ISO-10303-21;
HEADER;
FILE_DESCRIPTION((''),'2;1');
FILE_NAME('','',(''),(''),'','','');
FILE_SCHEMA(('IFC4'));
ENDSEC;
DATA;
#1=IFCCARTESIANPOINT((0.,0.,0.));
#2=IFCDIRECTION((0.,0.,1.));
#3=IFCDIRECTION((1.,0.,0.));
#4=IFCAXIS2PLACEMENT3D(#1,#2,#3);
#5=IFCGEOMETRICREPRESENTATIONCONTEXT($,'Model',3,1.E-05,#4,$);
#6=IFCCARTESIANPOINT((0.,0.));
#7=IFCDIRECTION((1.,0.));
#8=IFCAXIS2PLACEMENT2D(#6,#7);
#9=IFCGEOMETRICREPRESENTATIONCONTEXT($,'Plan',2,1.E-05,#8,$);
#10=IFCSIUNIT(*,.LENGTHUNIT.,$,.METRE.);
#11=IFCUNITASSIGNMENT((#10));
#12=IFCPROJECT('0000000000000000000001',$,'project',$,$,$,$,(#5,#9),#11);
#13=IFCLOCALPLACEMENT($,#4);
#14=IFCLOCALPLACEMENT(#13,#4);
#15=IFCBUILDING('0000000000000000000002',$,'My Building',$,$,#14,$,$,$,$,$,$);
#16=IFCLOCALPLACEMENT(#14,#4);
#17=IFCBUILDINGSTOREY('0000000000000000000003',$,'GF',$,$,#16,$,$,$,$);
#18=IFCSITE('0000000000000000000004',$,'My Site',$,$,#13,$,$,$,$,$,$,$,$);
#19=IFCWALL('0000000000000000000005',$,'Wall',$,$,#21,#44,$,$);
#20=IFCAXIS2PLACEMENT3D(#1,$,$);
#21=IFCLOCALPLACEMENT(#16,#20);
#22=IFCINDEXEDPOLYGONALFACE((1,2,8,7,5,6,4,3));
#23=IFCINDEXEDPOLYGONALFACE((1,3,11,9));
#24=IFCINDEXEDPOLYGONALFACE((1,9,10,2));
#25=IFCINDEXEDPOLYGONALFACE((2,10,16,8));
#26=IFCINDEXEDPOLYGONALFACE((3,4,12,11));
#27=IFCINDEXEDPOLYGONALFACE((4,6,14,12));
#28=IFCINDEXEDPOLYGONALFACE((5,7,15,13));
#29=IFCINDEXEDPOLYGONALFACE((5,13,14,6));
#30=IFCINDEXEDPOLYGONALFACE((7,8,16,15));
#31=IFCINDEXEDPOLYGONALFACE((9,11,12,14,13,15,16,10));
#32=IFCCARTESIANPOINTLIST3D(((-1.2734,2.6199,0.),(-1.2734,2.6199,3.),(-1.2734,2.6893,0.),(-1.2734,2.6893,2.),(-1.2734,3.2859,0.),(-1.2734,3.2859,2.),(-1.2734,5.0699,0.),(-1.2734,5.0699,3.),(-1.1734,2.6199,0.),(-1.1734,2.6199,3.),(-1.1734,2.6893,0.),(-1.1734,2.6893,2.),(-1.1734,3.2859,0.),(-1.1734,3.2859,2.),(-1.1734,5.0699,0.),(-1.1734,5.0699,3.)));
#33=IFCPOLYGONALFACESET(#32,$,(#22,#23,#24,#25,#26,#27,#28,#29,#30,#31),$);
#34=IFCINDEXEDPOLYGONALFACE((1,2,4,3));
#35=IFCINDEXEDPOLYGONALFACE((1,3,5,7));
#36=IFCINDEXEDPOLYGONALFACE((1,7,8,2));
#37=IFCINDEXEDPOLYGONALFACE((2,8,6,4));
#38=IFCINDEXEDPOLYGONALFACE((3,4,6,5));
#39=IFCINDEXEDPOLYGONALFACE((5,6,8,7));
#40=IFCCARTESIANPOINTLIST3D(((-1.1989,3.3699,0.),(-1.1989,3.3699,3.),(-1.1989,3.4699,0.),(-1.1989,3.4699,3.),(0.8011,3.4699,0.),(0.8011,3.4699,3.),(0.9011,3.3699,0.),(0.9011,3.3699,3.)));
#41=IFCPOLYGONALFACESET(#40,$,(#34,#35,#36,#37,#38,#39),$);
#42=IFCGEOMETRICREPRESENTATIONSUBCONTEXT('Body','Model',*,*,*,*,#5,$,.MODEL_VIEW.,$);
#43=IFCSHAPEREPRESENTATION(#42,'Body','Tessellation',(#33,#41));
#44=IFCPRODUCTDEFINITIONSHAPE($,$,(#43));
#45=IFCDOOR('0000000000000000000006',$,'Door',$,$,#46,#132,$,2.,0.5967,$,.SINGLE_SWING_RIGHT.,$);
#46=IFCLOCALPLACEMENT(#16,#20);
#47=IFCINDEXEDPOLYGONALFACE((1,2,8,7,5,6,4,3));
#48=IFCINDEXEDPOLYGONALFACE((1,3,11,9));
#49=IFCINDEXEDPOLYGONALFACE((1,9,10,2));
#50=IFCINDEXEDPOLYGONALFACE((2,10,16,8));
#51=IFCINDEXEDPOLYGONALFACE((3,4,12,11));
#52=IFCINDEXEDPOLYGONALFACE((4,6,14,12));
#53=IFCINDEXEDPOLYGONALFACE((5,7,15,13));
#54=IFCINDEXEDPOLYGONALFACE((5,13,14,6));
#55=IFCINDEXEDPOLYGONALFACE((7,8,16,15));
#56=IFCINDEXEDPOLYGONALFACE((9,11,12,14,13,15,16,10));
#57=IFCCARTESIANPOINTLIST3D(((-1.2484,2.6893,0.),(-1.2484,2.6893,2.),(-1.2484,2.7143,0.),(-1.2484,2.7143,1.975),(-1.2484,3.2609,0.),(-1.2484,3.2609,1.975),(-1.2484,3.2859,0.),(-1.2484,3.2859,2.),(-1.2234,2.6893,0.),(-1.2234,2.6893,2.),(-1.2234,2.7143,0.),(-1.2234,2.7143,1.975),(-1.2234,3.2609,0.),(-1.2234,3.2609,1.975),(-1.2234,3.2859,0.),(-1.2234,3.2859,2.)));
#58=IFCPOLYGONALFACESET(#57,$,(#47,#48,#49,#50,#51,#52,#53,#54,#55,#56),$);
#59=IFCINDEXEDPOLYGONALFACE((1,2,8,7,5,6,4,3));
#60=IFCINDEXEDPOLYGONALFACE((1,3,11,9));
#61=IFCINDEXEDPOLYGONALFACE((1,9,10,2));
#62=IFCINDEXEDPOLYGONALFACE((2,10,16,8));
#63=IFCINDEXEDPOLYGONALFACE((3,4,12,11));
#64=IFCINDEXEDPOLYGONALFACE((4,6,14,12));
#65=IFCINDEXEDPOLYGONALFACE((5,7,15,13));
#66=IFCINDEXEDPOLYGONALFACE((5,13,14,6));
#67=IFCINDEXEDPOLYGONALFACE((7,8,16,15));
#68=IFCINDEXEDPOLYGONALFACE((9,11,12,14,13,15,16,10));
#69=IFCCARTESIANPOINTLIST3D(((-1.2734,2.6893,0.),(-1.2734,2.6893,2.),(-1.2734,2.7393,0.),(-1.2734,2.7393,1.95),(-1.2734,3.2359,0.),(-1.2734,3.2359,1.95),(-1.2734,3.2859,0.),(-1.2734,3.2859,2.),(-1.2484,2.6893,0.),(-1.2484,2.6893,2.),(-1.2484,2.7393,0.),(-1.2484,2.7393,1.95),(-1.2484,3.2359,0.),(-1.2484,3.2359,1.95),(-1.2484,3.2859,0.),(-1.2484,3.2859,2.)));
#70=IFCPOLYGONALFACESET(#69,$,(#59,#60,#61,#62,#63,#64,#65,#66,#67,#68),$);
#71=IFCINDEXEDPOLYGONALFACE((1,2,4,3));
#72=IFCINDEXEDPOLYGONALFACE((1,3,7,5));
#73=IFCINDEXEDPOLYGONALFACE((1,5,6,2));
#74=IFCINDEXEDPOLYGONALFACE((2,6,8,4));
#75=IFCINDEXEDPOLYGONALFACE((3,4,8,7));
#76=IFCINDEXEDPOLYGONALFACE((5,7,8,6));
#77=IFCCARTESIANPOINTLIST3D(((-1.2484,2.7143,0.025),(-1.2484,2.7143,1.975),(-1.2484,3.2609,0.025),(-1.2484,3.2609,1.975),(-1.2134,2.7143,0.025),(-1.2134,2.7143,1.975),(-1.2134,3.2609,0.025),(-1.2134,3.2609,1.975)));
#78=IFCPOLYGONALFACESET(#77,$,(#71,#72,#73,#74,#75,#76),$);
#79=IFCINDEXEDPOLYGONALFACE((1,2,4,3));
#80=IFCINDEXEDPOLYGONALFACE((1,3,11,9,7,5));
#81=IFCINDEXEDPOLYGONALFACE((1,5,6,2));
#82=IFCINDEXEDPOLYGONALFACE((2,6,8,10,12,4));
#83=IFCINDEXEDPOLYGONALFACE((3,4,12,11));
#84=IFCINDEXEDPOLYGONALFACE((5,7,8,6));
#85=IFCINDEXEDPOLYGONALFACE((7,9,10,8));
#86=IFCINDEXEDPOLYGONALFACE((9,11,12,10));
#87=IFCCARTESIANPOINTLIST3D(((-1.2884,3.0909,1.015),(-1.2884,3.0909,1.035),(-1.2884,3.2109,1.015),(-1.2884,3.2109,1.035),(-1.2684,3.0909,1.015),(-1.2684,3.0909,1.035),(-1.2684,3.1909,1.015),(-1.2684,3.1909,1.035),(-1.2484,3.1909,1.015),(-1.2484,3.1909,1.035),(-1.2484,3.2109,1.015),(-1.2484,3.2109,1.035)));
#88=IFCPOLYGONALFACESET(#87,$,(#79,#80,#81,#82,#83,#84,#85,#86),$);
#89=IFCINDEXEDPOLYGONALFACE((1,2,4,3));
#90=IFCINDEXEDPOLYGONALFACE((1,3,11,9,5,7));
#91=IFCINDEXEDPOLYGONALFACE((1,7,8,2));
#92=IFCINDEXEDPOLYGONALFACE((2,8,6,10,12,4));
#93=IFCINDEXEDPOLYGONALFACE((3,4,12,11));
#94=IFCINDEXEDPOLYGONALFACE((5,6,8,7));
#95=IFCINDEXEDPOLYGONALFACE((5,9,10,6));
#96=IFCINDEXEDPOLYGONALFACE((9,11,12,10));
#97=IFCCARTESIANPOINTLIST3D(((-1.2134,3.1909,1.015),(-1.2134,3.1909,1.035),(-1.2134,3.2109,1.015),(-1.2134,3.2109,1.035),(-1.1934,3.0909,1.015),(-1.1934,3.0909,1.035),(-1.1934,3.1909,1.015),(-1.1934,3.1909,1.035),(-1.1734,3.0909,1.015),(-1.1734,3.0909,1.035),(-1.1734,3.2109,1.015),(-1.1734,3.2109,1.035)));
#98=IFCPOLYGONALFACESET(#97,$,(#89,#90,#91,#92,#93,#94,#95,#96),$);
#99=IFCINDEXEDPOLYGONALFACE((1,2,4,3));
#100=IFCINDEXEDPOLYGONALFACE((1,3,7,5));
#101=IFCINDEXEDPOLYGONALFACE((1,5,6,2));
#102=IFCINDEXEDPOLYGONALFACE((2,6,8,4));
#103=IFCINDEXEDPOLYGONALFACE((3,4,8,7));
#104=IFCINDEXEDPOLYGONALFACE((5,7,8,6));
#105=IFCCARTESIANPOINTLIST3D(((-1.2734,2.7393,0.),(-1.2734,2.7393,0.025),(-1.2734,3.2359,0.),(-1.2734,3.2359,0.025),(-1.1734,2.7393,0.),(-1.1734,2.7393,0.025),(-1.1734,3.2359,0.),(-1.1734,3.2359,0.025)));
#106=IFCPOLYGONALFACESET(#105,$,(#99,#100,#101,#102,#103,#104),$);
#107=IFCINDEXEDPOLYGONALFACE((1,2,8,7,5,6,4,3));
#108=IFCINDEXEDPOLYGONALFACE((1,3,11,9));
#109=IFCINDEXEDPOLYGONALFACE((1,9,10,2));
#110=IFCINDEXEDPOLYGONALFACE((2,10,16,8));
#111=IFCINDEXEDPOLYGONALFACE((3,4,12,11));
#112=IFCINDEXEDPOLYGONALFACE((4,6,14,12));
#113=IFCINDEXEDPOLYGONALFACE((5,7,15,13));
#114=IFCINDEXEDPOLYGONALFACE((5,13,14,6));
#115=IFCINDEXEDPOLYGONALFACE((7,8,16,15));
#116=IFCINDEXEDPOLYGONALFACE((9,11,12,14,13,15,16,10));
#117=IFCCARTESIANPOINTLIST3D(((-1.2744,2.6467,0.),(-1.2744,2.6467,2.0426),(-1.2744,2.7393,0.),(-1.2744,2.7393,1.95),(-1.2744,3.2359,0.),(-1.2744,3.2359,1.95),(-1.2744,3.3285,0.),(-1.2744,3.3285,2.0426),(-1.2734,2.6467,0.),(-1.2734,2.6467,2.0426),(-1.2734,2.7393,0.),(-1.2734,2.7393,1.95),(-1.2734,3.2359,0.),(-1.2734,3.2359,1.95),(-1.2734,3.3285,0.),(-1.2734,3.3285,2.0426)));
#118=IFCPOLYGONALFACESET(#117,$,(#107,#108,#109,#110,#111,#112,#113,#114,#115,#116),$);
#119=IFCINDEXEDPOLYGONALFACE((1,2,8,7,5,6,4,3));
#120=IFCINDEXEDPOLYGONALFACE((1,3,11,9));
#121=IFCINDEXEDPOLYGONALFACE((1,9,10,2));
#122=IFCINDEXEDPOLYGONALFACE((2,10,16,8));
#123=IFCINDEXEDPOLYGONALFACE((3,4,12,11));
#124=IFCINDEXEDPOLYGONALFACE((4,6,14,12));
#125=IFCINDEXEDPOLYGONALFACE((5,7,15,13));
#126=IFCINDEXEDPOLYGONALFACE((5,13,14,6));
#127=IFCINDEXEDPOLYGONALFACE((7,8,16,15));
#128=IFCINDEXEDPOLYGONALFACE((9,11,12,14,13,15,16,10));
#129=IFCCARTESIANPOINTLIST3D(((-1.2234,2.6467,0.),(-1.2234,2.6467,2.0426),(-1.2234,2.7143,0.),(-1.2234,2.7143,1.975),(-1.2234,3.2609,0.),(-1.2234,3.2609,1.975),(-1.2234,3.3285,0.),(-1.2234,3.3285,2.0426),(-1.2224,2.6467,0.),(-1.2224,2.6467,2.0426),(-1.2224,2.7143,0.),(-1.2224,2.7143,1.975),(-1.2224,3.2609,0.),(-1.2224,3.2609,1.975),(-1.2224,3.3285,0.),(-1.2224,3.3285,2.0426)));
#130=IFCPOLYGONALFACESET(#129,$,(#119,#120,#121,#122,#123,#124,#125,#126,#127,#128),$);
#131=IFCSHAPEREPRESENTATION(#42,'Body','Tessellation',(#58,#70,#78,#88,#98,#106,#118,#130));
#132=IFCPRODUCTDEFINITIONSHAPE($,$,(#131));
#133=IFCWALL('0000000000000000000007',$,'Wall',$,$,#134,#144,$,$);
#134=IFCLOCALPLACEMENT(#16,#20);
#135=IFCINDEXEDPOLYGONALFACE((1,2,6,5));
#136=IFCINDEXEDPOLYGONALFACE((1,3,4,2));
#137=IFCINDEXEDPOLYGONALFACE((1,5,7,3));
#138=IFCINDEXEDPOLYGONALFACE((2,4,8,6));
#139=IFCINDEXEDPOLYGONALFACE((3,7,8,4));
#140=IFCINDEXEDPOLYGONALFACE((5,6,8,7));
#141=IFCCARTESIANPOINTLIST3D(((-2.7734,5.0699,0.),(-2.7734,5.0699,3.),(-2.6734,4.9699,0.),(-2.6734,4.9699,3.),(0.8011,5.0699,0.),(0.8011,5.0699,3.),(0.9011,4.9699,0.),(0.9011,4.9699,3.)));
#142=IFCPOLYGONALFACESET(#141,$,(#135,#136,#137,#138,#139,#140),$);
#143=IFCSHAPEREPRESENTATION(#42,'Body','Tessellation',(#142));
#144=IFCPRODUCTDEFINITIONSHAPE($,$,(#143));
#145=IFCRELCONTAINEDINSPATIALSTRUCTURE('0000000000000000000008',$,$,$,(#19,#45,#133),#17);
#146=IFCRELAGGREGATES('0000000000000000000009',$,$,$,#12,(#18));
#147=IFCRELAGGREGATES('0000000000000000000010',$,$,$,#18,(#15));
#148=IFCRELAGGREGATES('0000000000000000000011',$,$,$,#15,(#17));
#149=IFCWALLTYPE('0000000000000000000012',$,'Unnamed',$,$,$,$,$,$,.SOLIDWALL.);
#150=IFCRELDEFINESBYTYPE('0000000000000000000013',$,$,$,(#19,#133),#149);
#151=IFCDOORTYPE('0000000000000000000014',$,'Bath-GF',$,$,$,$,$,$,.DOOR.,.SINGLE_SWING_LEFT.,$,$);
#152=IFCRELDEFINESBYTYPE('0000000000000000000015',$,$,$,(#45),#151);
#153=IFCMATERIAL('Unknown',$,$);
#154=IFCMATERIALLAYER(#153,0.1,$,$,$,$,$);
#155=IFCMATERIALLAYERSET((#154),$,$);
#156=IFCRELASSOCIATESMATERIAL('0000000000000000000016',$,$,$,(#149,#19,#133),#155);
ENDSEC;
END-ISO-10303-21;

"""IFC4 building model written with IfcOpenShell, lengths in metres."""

from ifc_helpers import new_model, entity, si_unit, frame, origin_with_axes, origin_2d_with_axis, place, context, subcontext, project, spatial, line, indexed_curve, outline, extrude, shape, source, transform, mapped, material, layer, layer_set, layer_usage, type_object, type_shapes, element, fill, save


model = new_model("IFC4")

# Units and contexts
model_context = context("Model", 3, precision=1e-05, world=origin_with_axes())
plan_context = context("Plan", 2, precision=1e-05, world=origin_2d_with_axis())
body_context_1 = subcontext(model_context, "Body", "Model", "MODEL_VIEW")
body_context_2 = subcontext(plan_context, "Body", "Plan", "PLAN_VIEW")
ifc_project = project(units=[si_unit("LENGTHUNIT", "METRE")], contexts=[model_context, plan_context])

# Site, building, storey
site_placement = place(None, origin_with_axes())
site = spatial("IfcSite", under=ifc_project, at=site_placement, Name="My Site")
building_placement = place(site_placement, origin_with_axes())
building = spatial("IfcBuilding", under=site, at=building_placement, Name="My Building")
storey_placement = place(building_placement, origin_with_axes())
storey = spatial("IfcBuildingStorey", under=building, at=storey_placement, Name="GF")

# Shared definitions
ifc_material = material(Name="Unknown")

# Shared definitions
ifc_layer_1 = layer(ifc_material, 0.1)
ifc_layer_set_1 = layer_set([ifc_layer_1])
wall_type = type_object("IfcWallType", Name="Unnamed", PredefinedType="SOLIDWALL", material=ifc_layer_set_1)

# Wall, opening, door
ifc_layer_usage_1 = layer_usage(ifc_layer_set_1, "AXIS2", "POSITIVE", 0.0)
wall_1_placement = place(storey_placement, frame((-1.1734, 2.6199, 0.0), z_axis=(0.0, 0.0, 1.0), x_axis=(0.0, 1.0, 0.0)))
wall_1 = element("IfcWall", 1, at=wall_1_placement, inside=storey, type_object=wall_type, material=ifc_layer_usage_1, Name="Wall", context=body_context_1, shape_type="SweptSolid", body=[
    extrude(outline(indexed_curve([(0.0, 0.0), (0.0, 0.1), (2.45, 0.1), (2.45, 0.0)], segments=[line(1, 2, 3, 4, 1)])), origin_with_axes(), (0.0, 0.0, 1.0), 3.0),
    extrude(outline(indexed_curve([(0.0, 0.0), (-0.1, 0.1), (2.0, 0.1), (2.0, 0.0)], segments=[line(1, 2, 3, 4, 1)])), frame((0.85, -1.9746, 0.0), z_axis=(0.0, 0.0, 1.0), x_axis=(0.0, 1.0, 0.0)), (0.0, 0.0, 1.0), 3.0),
])
shared_shape_1 = source(origin_with_axes(), body_context_1, "Body", "SweptSolid", [
    extrude(outline(indexed_curve([(0.0, 0.0), (0.5967, 0.0), (0.5967, 2.0), (0.0, 2.0)], segments=[line(1, 2, 3, 4, 1)])), frame((0.0, -1.0873, 0.0), z_axis=(0.0, -1.0, 0.0), x_axis=(1.0, 0.0, 0.0)), (0.0, 0.0, -1.0), 2.1746),
])
opening_1_placement = place(wall_1_placement, frame((0.666, 0.1, 0.0), z_axis=(0.0, 0.0, 1.0), x_axis=(-1.0, 0.0, 0.0)))
opening_1 = element("IfcOpeningElement", 2, at=opening_1_placement, cuts=wall_1, PredefinedType="OPENING", context=body_context_1, shape_type="MappedRepresentation", body=[
    mapped(shared_shape_1, transform((0.0, 0.0, 0.0), x_axis=(1.0, 0.0, 0.0), y_axis=(0.0, 1.0, 0.0), z_axis=(0.0, 0.0, 1.0), scale=1.0)),
])
door_type_1 = type_object("IfcDoorType", Name="Bath-GF", OperationType="SINGLE_SWING_LEFT", PredefinedType="DOOR")
shared_shape_2 = source(origin_with_axes(), body_context_1, "Body", "SweptSolid", [
    extrude(outline(indexed_curve([(0.0, 0.0), (0.0, 2.0), (0.5967, 2.0), (0.5967, 0.0), (0.5717, 0.0), (0.5717, 1.975), (0.025, 1.975), (0.025, 0.0)], segments=[line(1, 2, 3, 4, 5, 6, 7, 8, 1)])), frame((0.0, 0.025, 0.0), z_axis=(0.0, -1.0, 0.0), x_axis=(1.0, 0.0, 0.0)), (0.0, 0.0, -1.0), 0.025),
    extrude(outline(indexed_curve([(0.0, 0.0), (0.0, 2.0), (0.5967, 2.0), (0.5967, 0.0), (0.5467, 0.0), (0.5467, 1.95), (0.05, 1.95), (0.05, 0.0)], segments=[line(1, 2, 3, 4, 5, 6, 7, 8, 1)])), frame((0.0, 0.0, 0.0), z_axis=(0.0, -1.0, 0.0), x_axis=(1.0, 0.0, 0.0)), (0.0, 0.0, -1.0), 0.025),
    extrude(outline(indexed_curve([(0.0, 0.0), (0.5467, 0.0), (0.5467, 0.035), (0.0, 0.035)], segments=[line(1, 2, 3, 4, 1)])), frame((0.025, 0.025, 0.025), z_axis=(0.0, 0.0, 1.0), x_axis=(1.0, 0.0, 0.0)), (0.0, 0.0, 1.0), 1.95),
    extrude(outline(indexed_curve([(0.0, 0.0), (0.0, -0.04), (0.12, -0.04), (0.12, -0.02), (0.02, -0.02), (0.02, 0.0)], segments=[line(1, 2, 3, 4, 5, 6, 1)])), frame((0.075, 0.025, 1.015), z_axis=(0.0, 0.0, 1.0), x_axis=(1.0, 0.0, 0.0)), (0.0, 0.0, 1.0), 0.02),
    extrude(outline(indexed_curve([(0.0, 0.0), (0.0, 0.04), (0.12, 0.04), (0.12, 0.02), (0.02, 0.02), (0.02, 0.0)], segments=[line(1, 2, 3, 4, 5, 6, 1)])), frame((0.075, 0.06, 1.015), z_axis=(0.0, 0.0, 1.0), x_axis=(1.0, 0.0, 0.0)), (0.0, 0.0, 1.0), 0.02),
    extrude(outline(indexed_curve([(0.0, 0.0), (0.4967, 0.0), (0.4967, 0.1), (0.0, 0.1)], segments=[line(1, 2, 3, 4, 1)])), frame((0.05, 0.0, 0.0), z_axis=(0.0, 0.0, 1.0), x_axis=(1.0, 0.0, 0.0)), (0.0, 0.0, 1.0), 0.025),
    extrude(outline(indexed_curve([(0.0, 0.0), (0.0, 2.0426), (0.6819, 2.0426), (0.6819, 0.0), (0.5893, 0.0), (0.5893, 1.95), (0.0926, 1.95), (0.0926, 0.0)], segments=[line(1, 2, 3, 4, 5, 6, 7, 8, 1)])), frame((-0.0426, -0.001, 0.0), z_axis=(0.0, -1.0, 0.0), x_axis=(1.0, 0.0, 0.0)), (0.0, 0.0, -1.0), 0.001),
    extrude(outline(indexed_curve([(0.0, 0.0), (0.0, 2.0426), (0.6819, 2.0426), (0.6819, 0.0), (0.6143, 0.0), (0.6143, 1.975), (0.0676, 1.975), (0.0676, 0.0)], segments=[line(1, 2, 3, 4, 5, 6, 7, 8, 1)])), frame((-0.0426, 0.05, 0.0), z_axis=(0.0, -1.0, 0.0), x_axis=(1.0, 0.0, 0.0)), (0.0, 0.0, -1.0), 0.001),
])
shared_shape_3 = source(origin_with_axes(), body_context_2, "Body", "Curve2D", [
    entity("IfcIndexedPolyCurve", entity("IfcCartesianPointList2D", [[0.0, 0.0], [0.0, 0.05], [0.025, 0.05], [0.025, 0.025], [0.05, 0.025], [0.05, 0.0]]), [entity("IfcLineIndex", [1, 2, 3, 4, 5, 6, 1])]),
    entity("IfcIndexedPolyCurve", entity("IfcCartesianPointList2D", [[0.5967, 0.0], [0.5967, 0.05], [0.5717, 0.05], [0.5717, 0.025], [0.5467, 0.025], [0.5467, 0.0]]), [entity("IfcLineIndex", [1, 2, 3, 4, 5, 6, 1])]),
    entity("IfcTrimmedCurve", entity("IfcEllipse", entity("IfcAxis2Placement2D", entity("IfcCartesianPoint", [0.5367, 0.05]), entity("IfcDirection", [1.0, 0.0])), 0.5117, 0.5467), [entity("IfcCartesianPoint", [0.5367, 0.5967])], [entity("IfcCartesianPoint", [0.025, 0.05])], True, "CARTESIAN"),
    entity("IfcIndexedPolyCurve", entity("IfcCartesianPointList2D", [[0.5717, 0.05], [0.5367, 0.05], [0.5367, 0.5967], [0.5717, 0.5967]]), [entity("IfcLineIndex", [1, 2, 3, 4, 1])]),
])
type_shapes(door_type_1, [shared_shape_2, shared_shape_3])
door_1_placement = place(opening_1_placement, frame((0.0, 0.0, 0.0), z_axis=(0.0, 0.0, 1.0), x_axis=(1.0, 0.0, 0.0)))
door_1 = element("IfcDoor", 3, at=door_1_placement, inside=storey, type_object=door_type_1, Name="Door", OperationType="SINGLE_SWING_RIGHT", OverallHeight=2.0, OverallWidth=0.5967, shapes=[
    shape(body_context_1, "Body", "MappedRepresentation", [mapped(shared_shape_2, transform((0.0, 0.0, 0.0), x_axis=(1.0, 0.0, 0.0), y_axis=(0.0, 1.0, 0.0), z_axis=(0.0, 0.0, 1.0), scale=1.0))]),
    shape(body_context_2, "Body", "MappedRepresentation", [mapped(shared_shape_3, transform((0.0, 0.0, 0.0), x_axis=(1.0, 0.0, 0.0), y_axis=(0.0, 1.0, 0.0), z_axis=(0.0, 0.0, 1.0), scale=1.0))]),
])
fill(opening_1, door_1)

# Wall
ifc_layer_usage_2 = layer_usage(ifc_layer_set_1, "AXIS2", "POSITIVE", 0.0)
wall_2_placement = place(storey_placement, frame((0.8011, 5.0699, 0.0), z_axis=(0.0, 0.0, 1.0), x_axis=(-1.0, 0.0, 0.0)))
element("IfcWall", 4, at=wall_2_placement, inside=storey, type_object=wall_type, material=ifc_layer_usage_2, Name="Wall", context=body_context_1, shape_type="SweptSolid", body=[
    extrude(outline(indexed_curve([(0.0, 0.0), (-0.1, 0.1), (3.4745, 0.1), (3.5745, 0.0)], segments=[line(1, 2, 3, 4, 1)])), origin_with_axes(), (0.0, 0.0, 1.0), 3.0),
])

save(model, "model.ifc")
